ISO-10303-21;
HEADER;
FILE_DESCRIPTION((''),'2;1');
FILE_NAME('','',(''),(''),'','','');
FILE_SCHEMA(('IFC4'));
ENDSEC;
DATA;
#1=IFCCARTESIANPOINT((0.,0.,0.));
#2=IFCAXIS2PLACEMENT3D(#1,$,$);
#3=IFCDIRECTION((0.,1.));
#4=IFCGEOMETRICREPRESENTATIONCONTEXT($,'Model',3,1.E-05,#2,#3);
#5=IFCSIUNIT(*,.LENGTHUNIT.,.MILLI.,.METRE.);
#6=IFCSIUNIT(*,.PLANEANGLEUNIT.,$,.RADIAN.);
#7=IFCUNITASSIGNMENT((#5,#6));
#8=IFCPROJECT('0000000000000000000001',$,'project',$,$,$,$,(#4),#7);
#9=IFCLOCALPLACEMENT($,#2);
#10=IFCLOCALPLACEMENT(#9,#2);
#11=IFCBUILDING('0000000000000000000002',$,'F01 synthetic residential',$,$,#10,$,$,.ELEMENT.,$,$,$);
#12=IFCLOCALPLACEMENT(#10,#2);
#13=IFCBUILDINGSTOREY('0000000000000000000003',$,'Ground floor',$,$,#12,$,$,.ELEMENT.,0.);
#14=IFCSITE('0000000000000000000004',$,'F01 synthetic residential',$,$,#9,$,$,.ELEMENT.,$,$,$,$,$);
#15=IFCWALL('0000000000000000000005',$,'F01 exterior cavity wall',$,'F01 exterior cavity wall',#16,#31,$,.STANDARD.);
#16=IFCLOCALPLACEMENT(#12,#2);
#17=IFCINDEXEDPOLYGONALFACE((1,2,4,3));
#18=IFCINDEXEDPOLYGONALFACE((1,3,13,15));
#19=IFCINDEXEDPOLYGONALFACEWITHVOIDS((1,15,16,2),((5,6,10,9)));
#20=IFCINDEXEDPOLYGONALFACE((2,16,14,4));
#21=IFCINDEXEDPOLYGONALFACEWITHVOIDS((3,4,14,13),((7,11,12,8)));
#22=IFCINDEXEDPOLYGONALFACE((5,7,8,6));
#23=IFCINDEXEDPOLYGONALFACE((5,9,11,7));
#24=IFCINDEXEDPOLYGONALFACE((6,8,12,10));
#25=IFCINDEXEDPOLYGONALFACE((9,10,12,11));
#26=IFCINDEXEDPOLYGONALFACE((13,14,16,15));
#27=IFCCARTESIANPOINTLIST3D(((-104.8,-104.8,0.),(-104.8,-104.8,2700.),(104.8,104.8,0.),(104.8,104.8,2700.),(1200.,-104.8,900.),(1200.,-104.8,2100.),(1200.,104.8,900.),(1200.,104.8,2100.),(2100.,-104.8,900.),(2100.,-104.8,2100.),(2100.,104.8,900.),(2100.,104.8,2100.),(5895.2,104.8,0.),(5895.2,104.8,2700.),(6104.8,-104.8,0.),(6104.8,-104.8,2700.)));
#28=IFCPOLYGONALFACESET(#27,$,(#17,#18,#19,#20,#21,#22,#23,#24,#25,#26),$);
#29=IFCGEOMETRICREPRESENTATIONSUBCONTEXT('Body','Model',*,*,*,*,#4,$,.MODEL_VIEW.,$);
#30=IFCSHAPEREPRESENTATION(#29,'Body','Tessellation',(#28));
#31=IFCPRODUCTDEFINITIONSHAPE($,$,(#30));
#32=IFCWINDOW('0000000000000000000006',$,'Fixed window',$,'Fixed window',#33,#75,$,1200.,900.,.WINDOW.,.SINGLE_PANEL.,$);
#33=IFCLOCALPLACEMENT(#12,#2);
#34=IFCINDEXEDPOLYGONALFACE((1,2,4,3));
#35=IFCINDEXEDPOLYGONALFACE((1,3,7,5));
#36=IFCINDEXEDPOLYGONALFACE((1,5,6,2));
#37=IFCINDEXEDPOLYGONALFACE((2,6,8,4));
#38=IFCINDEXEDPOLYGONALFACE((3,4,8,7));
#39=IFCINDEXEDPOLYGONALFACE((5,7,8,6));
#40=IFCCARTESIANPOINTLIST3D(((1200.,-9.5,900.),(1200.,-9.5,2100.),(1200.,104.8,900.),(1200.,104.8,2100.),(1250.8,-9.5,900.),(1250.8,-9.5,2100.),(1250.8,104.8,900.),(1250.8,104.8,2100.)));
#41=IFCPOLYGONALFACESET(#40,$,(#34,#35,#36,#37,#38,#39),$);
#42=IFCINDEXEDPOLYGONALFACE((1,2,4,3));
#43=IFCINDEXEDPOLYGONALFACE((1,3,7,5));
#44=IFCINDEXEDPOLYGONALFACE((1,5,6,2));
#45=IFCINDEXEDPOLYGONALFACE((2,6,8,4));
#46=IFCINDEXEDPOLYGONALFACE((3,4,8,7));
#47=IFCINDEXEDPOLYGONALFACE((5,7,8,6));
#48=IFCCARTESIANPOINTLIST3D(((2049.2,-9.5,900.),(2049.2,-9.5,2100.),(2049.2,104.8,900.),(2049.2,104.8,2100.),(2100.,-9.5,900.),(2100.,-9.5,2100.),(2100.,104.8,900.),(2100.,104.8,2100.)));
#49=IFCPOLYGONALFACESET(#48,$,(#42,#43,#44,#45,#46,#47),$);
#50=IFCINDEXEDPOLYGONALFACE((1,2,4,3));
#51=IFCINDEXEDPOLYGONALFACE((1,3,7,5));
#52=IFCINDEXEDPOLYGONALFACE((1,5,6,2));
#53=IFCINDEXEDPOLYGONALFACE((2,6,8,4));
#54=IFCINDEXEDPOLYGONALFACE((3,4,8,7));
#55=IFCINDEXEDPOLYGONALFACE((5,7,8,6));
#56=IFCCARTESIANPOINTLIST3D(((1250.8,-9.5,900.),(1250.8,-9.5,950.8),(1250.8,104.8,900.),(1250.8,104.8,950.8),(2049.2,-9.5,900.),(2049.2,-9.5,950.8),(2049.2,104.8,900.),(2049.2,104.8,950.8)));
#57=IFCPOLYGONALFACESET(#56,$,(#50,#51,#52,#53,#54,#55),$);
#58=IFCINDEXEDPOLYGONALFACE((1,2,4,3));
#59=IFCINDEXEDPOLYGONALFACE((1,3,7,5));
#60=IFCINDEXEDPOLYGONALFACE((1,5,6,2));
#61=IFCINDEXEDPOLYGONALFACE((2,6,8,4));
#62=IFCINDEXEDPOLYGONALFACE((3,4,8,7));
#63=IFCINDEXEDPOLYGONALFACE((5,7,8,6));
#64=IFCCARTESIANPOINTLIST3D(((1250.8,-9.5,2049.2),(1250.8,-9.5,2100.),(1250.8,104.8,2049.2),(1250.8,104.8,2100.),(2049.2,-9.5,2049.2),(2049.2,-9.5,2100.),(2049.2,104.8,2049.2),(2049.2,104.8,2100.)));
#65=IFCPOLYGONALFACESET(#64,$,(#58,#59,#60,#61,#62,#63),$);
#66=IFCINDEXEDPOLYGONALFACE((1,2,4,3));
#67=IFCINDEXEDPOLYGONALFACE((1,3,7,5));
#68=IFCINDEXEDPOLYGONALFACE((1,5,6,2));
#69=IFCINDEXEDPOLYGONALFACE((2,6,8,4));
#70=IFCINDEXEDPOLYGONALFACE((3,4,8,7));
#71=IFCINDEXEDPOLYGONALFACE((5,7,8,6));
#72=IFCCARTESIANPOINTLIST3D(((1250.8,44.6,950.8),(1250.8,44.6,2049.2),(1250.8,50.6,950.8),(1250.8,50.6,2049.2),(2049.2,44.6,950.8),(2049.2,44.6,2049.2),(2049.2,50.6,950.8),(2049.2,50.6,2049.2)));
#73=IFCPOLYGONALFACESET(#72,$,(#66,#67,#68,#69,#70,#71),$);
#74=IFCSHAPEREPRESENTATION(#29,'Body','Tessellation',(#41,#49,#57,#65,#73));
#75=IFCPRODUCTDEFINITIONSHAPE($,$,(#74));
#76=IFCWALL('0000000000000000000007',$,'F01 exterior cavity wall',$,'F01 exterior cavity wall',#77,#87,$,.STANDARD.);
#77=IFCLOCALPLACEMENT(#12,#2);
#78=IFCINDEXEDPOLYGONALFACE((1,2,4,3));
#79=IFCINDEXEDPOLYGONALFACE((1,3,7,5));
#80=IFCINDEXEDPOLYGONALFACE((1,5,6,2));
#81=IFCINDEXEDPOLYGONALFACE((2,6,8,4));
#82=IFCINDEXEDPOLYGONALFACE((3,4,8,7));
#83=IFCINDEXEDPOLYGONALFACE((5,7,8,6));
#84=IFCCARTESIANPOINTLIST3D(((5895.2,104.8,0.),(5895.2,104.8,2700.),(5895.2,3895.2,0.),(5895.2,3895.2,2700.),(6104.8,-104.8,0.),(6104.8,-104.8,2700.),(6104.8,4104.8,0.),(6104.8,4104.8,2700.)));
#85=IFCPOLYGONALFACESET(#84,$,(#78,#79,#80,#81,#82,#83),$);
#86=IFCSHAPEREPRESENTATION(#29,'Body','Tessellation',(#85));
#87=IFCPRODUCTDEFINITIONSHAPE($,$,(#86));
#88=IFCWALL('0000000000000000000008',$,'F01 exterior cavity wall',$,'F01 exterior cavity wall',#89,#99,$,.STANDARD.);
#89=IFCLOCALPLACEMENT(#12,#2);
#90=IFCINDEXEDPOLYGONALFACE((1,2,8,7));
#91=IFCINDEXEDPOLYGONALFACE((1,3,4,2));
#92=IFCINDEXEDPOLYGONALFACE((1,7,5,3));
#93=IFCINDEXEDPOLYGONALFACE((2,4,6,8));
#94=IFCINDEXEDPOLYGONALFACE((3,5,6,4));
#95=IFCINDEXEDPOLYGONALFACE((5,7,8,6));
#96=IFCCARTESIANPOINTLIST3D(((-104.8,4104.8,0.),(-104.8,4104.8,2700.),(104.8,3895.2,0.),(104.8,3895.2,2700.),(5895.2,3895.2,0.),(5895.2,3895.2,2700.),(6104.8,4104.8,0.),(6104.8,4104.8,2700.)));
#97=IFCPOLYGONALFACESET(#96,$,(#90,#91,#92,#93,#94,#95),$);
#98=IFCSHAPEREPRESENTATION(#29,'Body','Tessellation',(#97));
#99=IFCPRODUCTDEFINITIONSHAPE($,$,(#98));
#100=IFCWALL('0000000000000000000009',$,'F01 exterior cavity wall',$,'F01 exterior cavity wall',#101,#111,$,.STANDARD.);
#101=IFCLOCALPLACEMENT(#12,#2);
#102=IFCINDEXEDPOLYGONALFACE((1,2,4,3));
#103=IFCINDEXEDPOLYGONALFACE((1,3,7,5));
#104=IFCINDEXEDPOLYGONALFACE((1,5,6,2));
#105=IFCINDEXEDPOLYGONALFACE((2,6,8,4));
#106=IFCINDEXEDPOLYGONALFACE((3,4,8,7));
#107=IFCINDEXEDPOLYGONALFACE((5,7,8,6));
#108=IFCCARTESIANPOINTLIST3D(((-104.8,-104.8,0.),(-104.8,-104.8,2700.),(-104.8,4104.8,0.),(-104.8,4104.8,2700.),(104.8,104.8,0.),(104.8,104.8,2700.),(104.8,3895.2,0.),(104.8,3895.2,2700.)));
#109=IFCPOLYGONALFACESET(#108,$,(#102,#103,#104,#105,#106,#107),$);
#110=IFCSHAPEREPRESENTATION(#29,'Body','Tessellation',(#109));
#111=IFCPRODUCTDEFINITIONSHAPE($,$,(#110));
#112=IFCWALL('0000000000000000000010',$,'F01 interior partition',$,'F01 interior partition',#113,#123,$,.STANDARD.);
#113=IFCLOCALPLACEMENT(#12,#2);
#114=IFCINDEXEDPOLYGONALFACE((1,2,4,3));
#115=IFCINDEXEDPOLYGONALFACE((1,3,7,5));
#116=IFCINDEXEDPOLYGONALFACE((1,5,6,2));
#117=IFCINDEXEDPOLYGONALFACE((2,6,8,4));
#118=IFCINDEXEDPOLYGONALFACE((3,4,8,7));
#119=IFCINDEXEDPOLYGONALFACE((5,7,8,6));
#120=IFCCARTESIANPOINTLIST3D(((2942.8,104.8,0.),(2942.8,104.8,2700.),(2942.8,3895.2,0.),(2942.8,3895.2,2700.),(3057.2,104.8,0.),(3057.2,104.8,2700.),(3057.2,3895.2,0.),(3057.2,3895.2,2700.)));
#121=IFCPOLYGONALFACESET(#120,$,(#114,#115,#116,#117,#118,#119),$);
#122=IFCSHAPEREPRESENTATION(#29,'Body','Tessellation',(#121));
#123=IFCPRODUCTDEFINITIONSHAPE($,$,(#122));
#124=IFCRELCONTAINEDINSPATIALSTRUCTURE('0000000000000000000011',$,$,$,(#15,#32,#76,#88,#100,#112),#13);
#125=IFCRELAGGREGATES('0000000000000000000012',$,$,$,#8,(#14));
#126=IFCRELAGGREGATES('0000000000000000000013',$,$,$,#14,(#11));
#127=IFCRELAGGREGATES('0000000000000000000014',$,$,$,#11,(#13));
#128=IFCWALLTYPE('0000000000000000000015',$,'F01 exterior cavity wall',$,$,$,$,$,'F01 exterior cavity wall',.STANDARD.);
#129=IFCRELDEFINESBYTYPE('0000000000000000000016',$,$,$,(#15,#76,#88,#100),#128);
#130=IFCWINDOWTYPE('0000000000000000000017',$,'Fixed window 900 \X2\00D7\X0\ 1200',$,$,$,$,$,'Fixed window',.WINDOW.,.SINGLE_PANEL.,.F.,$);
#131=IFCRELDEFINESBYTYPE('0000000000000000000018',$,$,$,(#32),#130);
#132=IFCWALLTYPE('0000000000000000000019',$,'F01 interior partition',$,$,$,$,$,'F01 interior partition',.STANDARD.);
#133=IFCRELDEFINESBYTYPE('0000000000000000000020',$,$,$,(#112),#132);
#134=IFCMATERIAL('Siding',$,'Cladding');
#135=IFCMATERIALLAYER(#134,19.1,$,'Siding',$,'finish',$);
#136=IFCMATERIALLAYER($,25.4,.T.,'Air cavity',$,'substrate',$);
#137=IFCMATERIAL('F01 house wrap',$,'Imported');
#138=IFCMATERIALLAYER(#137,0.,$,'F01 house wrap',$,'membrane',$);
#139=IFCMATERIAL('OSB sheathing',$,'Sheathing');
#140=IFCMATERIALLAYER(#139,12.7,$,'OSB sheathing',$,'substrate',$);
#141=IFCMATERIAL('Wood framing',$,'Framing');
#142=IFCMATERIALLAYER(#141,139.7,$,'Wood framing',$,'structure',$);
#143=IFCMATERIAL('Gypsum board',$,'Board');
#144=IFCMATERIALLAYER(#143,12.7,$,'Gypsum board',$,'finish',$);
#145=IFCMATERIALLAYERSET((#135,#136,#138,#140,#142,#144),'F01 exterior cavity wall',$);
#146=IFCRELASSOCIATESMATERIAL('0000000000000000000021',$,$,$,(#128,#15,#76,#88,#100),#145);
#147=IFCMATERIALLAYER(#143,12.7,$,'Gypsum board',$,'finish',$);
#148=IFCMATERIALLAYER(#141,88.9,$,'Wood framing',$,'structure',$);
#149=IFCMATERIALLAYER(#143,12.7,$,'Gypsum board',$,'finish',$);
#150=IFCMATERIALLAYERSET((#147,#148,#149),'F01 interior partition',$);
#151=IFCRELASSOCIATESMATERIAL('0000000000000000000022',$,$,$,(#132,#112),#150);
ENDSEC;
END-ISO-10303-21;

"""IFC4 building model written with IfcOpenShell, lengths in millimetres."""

from ifc_helpers import new_model, si_unit, direction, frame, origin, origin_with_axes, place, context, subcontext, project, spatial, polyline, outline, extrude, material, layer, layer_set, layer_usage, type_object, element, fill, save


model = new_model("IFC4")

# Units and contexts
model_context = context("Model", 3, precision=1e-05, world=origin(), true_north=direction((0.0, 1.0)))
body_context = subcontext(model_context, "Body", "Model", "MODEL_VIEW")
ifc_project = project(units=[si_unit("LENGTHUNIT", "METRE", prefix="MILLI"), si_unit("PLANEANGLEUNIT", "RADIAN")], contexts=[model_context])

# Site, building, storey
site_placement = place(None, origin())
site = spatial("IfcSite", under=ifc_project, at=site_placement, Name="F01 synthetic residential", CompositionType="ELEMENT")
building_placement = place(site_placement, origin())
building = spatial("IfcBuilding", under=site, at=building_placement, Name="F01 synthetic residential", CompositionType="ELEMENT")
storey_placement = place(building_placement, origin())
storey = spatial("IfcBuildingStorey", under=building, at=storey_placement, Name="Ground floor", CompositionType="ELEMENT", Elevation=0.0)

# Wall, opening, window
ifc_material_1 = material(Name="Siding", Category="Cladding")
ifc_layer_1 = layer(ifc_material_1, 19.1, Name="Siding", Category="finish")
ifc_layer_2 = layer(None, 25.4, ventilated=True, Name="Air cavity", Category="substrate")
ifc_material_2 = material(Name="F01 house wrap", Category="Imported")
ifc_layer_3 = layer(ifc_material_2, 0.0, Name="F01 house wrap", Category="membrane")
ifc_material_3 = material(Name="OSB sheathing", Category="Sheathing")
ifc_layer_4 = layer(ifc_material_3, 12.7, Name="OSB sheathing", Category="substrate")
ifc_material_4 = material(Name="Wood framing", Category="Framing")
ifc_layer_5 = layer(ifc_material_4, 139.7, Name="Wood framing", Category="structure")
ifc_material_5 = material(Name="Gypsum board", Category="Board")
ifc_layer_6 = layer(ifc_material_5, 12.7, Name="Gypsum board", Category="finish")
ifc_layer_set_1 = layer_set([ifc_layer_1, ifc_layer_2, ifc_layer_3, ifc_layer_4, ifc_layer_5, ifc_layer_6], Name="F01 exterior cavity wall")
ifc_layer_usage_1 = layer_usage(ifc_layer_set_1, "AXIS2", "POSITIVE", -104.8)
wall_type_1 = type_object("IfcWallType", Name="F01 exterior cavity wall", ElementType="F01 exterior cavity wall", PredefinedType="STANDARD", material=ifc_layer_set_1)
wall_1_placement = place(storey_placement, origin_with_axes())
wall_1 = element("IfcWall", 1, at=wall_1_placement, inside=storey, type_object=wall_type_1, material=ifc_layer_usage_1, Name="F01 exterior cavity wall", ObjectType="F01 exterior cavity wall", PredefinedType="STANDARD", context=body_context, shape_type="SweptSolid", body=[
    extrude(outline(polyline([(-104.8, -104.8), (6104.8, -104.8), (5895.2, 104.8), (104.8, 104.8), (-104.8, -104.8)])), origin(), (0.0, 0.0, 1.0), 2700.0),
])
opening_placement = place(wall_1_placement, frame((1200.0, 0.0, 900.0), z_axis=(0.0, 0.0, 1.0), x_axis=(1.0, 0.0, 0.0)))
opening = element("IfcOpeningElement", 2, at=opening_placement, cuts=wall_1, PredefinedType="OPENING", context=body_context, shape_type="SweptSolid", body=[
    extrude(outline(polyline([(0.0, -114.8), (900.0, -114.8), (900.0, 114.8), (0.0, 114.8), (0.0, -114.8)])), origin(), (0.0, 0.0, 1.0), 1200.0),
])
window_type = type_object("IfcWindowType", Name="Fixed window 900 × 1200", ElementType="Fixed window", ParameterTakesPrecedence=False, PartitioningType="SINGLE_PANEL", PredefinedType="WINDOW")
window_placement = place(opening_placement, origin_with_axes())
window = element("IfcWindow", 3, at=window_placement, inside=storey, type_object=window_type, Name="Fixed window", ObjectType="Fixed window", OverallHeight=1200.0, OverallWidth=900.0, PartitioningType="SINGLE_PANEL", PredefinedType="WINDOW", context=body_context, shape_type="SweptSolid", body=[
    extrude(outline(polyline([(0.0, -9.5), (50.8, -9.5), (50.8, 104.8), (0.0, 104.8), (0.0, -9.5)])), origin(), (0.0, 0.0, 1.0), 1200.0),
    extrude(outline(polyline([(849.2, -9.5), (900.0, -9.5), (900.0, 104.8), (849.2, 104.8), (849.2, -9.5)])), origin(), (0.0, 0.0, 1.0), 1200.0),
    extrude(outline(polyline([(50.8, -9.5), (849.2, -9.5), (849.2, 104.8), (50.8, 104.8), (50.8, -9.5)])), origin(), (0.0, 0.0, 1.0), 50.8),
    extrude(outline(polyline([(50.8, -9.5), (849.2, -9.5), (849.2, 104.8), (50.8, 104.8), (50.8, -9.5)])), frame((0.0, 0.0, 1149.2)), (0.0, 0.0, 1.0), 50.8),
    extrude(outline(polyline([(50.8, 44.6), (849.2, 44.6), (849.2, 50.6), (50.8, 50.6), (50.8, 44.6)])), frame((0.0, 0.0, 50.8)), (0.0, 0.0, 1.0), 1098.4),
])
fill(opening, window)

# Walls
ifc_layer_usage_2 = layer_usage(ifc_layer_set_1, "AXIS2", "POSITIVE", -104.8)
wall_2_placement = place(storey_placement, frame((6000.0, 0.0, 0.0), z_axis=(0.0, 0.0, 1.0), x_axis=(0.0, 1.0, 0.0)))
element("IfcWall", 4, at=wall_2_placement, inside=storey, type_object=wall_type_1, material=ifc_layer_usage_2, Name="F01 exterior cavity wall", ObjectType="F01 exterior cavity wall", PredefinedType="STANDARD", context=body_context, shape_type="SweptSolid", body=[
    extrude(outline(polyline([(-104.8, -104.8), (4104.8, -104.8), (3895.2, 104.8), (104.8, 104.8), (-104.8, -104.8)])), origin(), (0.0, 0.0, 1.0), 2700.0),
])
ifc_layer_usage_3 = layer_usage(ifc_layer_set_1, "AXIS2", "POSITIVE", -104.8)
wall_3_placement = place(storey_placement, frame((6000.0, 4000.0, 0.0), z_axis=(0.0, 0.0, 1.0), x_axis=(-1.0, 0.0, 0.0)))
element("IfcWall", 5, at=wall_3_placement, inside=storey, type_object=wall_type_1, material=ifc_layer_usage_3, Name="F01 exterior cavity wall", ObjectType="F01 exterior cavity wall", PredefinedType="STANDARD", context=body_context, shape_type="SweptSolid", body=[
    extrude(outline(polyline([(-104.8, -104.8), (6104.8, -104.8), (5895.2, 104.8), (104.8, 104.8), (-104.8, -104.8)])), origin(), (0.0, 0.0, 1.0), 2700.0),
])
ifc_layer_usage_4 = layer_usage(ifc_layer_set_1, "AXIS2", "POSITIVE", -104.8)
wall_4_placement = place(storey_placement, frame((0.0, 4000.0, 0.0), z_axis=(0.0, 0.0, 1.0), x_axis=(0.0, -1.0, 0.0)))
element("IfcWall", 6, at=wall_4_placement, inside=storey, type_object=wall_type_1, material=ifc_layer_usage_4, Name="F01 exterior cavity wall", ObjectType="F01 exterior cavity wall", PredefinedType="STANDARD", context=body_context, shape_type="SweptSolid", body=[
    extrude(outline(polyline([(-104.8, -104.8), (4104.8, -104.8), (3895.2, 104.8), (104.8, 104.8), (-104.8, -104.8)])), origin(), (0.0, 0.0, 1.0), 2700.0),
])
ifc_layer_7 = layer(ifc_material_5, 12.7, Name="Gypsum board", Category="finish")
ifc_layer_8 = layer(ifc_material_4, 88.9, Name="Wood framing", Category="structure")
ifc_layer_9 = layer(ifc_material_5, 12.7, Name="Gypsum board", Category="finish")
ifc_layer_set_2 = layer_set([ifc_layer_7, ifc_layer_8, ifc_layer_9], Name="F01 interior partition")
ifc_layer_usage_5 = layer_usage(ifc_layer_set_2, "AXIS2", "NEGATIVE", 57.1)
wall_type_2 = type_object("IfcWallType", Name="F01 interior partition", ElementType="F01 interior partition", PredefinedType="STANDARD", material=ifc_layer_set_2)
wall_5_placement = place(storey_placement, frame((3000.0, 0.0, 0.0), z_axis=(0.0, 0.0, 1.0), x_axis=(0.0, 1.0, 0.0)))
element("IfcWall", 7, at=wall_5_placement, inside=storey, type_object=wall_type_2, material=ifc_layer_usage_5, Name="F01 interior partition", ObjectType="F01 interior partition", PredefinedType="STANDARD", context=body_context, shape_type="SweptSolid", body=[
    extrude(outline(polyline([(104.8, -57.1), (3895.2, -57.1), (3895.2, 57.1), (104.8, 57.1), (104.8, -57.1)])), origin(), (0.0, 0.0, 1.0), 2700.0),
])

save(model, "model.ifc")
